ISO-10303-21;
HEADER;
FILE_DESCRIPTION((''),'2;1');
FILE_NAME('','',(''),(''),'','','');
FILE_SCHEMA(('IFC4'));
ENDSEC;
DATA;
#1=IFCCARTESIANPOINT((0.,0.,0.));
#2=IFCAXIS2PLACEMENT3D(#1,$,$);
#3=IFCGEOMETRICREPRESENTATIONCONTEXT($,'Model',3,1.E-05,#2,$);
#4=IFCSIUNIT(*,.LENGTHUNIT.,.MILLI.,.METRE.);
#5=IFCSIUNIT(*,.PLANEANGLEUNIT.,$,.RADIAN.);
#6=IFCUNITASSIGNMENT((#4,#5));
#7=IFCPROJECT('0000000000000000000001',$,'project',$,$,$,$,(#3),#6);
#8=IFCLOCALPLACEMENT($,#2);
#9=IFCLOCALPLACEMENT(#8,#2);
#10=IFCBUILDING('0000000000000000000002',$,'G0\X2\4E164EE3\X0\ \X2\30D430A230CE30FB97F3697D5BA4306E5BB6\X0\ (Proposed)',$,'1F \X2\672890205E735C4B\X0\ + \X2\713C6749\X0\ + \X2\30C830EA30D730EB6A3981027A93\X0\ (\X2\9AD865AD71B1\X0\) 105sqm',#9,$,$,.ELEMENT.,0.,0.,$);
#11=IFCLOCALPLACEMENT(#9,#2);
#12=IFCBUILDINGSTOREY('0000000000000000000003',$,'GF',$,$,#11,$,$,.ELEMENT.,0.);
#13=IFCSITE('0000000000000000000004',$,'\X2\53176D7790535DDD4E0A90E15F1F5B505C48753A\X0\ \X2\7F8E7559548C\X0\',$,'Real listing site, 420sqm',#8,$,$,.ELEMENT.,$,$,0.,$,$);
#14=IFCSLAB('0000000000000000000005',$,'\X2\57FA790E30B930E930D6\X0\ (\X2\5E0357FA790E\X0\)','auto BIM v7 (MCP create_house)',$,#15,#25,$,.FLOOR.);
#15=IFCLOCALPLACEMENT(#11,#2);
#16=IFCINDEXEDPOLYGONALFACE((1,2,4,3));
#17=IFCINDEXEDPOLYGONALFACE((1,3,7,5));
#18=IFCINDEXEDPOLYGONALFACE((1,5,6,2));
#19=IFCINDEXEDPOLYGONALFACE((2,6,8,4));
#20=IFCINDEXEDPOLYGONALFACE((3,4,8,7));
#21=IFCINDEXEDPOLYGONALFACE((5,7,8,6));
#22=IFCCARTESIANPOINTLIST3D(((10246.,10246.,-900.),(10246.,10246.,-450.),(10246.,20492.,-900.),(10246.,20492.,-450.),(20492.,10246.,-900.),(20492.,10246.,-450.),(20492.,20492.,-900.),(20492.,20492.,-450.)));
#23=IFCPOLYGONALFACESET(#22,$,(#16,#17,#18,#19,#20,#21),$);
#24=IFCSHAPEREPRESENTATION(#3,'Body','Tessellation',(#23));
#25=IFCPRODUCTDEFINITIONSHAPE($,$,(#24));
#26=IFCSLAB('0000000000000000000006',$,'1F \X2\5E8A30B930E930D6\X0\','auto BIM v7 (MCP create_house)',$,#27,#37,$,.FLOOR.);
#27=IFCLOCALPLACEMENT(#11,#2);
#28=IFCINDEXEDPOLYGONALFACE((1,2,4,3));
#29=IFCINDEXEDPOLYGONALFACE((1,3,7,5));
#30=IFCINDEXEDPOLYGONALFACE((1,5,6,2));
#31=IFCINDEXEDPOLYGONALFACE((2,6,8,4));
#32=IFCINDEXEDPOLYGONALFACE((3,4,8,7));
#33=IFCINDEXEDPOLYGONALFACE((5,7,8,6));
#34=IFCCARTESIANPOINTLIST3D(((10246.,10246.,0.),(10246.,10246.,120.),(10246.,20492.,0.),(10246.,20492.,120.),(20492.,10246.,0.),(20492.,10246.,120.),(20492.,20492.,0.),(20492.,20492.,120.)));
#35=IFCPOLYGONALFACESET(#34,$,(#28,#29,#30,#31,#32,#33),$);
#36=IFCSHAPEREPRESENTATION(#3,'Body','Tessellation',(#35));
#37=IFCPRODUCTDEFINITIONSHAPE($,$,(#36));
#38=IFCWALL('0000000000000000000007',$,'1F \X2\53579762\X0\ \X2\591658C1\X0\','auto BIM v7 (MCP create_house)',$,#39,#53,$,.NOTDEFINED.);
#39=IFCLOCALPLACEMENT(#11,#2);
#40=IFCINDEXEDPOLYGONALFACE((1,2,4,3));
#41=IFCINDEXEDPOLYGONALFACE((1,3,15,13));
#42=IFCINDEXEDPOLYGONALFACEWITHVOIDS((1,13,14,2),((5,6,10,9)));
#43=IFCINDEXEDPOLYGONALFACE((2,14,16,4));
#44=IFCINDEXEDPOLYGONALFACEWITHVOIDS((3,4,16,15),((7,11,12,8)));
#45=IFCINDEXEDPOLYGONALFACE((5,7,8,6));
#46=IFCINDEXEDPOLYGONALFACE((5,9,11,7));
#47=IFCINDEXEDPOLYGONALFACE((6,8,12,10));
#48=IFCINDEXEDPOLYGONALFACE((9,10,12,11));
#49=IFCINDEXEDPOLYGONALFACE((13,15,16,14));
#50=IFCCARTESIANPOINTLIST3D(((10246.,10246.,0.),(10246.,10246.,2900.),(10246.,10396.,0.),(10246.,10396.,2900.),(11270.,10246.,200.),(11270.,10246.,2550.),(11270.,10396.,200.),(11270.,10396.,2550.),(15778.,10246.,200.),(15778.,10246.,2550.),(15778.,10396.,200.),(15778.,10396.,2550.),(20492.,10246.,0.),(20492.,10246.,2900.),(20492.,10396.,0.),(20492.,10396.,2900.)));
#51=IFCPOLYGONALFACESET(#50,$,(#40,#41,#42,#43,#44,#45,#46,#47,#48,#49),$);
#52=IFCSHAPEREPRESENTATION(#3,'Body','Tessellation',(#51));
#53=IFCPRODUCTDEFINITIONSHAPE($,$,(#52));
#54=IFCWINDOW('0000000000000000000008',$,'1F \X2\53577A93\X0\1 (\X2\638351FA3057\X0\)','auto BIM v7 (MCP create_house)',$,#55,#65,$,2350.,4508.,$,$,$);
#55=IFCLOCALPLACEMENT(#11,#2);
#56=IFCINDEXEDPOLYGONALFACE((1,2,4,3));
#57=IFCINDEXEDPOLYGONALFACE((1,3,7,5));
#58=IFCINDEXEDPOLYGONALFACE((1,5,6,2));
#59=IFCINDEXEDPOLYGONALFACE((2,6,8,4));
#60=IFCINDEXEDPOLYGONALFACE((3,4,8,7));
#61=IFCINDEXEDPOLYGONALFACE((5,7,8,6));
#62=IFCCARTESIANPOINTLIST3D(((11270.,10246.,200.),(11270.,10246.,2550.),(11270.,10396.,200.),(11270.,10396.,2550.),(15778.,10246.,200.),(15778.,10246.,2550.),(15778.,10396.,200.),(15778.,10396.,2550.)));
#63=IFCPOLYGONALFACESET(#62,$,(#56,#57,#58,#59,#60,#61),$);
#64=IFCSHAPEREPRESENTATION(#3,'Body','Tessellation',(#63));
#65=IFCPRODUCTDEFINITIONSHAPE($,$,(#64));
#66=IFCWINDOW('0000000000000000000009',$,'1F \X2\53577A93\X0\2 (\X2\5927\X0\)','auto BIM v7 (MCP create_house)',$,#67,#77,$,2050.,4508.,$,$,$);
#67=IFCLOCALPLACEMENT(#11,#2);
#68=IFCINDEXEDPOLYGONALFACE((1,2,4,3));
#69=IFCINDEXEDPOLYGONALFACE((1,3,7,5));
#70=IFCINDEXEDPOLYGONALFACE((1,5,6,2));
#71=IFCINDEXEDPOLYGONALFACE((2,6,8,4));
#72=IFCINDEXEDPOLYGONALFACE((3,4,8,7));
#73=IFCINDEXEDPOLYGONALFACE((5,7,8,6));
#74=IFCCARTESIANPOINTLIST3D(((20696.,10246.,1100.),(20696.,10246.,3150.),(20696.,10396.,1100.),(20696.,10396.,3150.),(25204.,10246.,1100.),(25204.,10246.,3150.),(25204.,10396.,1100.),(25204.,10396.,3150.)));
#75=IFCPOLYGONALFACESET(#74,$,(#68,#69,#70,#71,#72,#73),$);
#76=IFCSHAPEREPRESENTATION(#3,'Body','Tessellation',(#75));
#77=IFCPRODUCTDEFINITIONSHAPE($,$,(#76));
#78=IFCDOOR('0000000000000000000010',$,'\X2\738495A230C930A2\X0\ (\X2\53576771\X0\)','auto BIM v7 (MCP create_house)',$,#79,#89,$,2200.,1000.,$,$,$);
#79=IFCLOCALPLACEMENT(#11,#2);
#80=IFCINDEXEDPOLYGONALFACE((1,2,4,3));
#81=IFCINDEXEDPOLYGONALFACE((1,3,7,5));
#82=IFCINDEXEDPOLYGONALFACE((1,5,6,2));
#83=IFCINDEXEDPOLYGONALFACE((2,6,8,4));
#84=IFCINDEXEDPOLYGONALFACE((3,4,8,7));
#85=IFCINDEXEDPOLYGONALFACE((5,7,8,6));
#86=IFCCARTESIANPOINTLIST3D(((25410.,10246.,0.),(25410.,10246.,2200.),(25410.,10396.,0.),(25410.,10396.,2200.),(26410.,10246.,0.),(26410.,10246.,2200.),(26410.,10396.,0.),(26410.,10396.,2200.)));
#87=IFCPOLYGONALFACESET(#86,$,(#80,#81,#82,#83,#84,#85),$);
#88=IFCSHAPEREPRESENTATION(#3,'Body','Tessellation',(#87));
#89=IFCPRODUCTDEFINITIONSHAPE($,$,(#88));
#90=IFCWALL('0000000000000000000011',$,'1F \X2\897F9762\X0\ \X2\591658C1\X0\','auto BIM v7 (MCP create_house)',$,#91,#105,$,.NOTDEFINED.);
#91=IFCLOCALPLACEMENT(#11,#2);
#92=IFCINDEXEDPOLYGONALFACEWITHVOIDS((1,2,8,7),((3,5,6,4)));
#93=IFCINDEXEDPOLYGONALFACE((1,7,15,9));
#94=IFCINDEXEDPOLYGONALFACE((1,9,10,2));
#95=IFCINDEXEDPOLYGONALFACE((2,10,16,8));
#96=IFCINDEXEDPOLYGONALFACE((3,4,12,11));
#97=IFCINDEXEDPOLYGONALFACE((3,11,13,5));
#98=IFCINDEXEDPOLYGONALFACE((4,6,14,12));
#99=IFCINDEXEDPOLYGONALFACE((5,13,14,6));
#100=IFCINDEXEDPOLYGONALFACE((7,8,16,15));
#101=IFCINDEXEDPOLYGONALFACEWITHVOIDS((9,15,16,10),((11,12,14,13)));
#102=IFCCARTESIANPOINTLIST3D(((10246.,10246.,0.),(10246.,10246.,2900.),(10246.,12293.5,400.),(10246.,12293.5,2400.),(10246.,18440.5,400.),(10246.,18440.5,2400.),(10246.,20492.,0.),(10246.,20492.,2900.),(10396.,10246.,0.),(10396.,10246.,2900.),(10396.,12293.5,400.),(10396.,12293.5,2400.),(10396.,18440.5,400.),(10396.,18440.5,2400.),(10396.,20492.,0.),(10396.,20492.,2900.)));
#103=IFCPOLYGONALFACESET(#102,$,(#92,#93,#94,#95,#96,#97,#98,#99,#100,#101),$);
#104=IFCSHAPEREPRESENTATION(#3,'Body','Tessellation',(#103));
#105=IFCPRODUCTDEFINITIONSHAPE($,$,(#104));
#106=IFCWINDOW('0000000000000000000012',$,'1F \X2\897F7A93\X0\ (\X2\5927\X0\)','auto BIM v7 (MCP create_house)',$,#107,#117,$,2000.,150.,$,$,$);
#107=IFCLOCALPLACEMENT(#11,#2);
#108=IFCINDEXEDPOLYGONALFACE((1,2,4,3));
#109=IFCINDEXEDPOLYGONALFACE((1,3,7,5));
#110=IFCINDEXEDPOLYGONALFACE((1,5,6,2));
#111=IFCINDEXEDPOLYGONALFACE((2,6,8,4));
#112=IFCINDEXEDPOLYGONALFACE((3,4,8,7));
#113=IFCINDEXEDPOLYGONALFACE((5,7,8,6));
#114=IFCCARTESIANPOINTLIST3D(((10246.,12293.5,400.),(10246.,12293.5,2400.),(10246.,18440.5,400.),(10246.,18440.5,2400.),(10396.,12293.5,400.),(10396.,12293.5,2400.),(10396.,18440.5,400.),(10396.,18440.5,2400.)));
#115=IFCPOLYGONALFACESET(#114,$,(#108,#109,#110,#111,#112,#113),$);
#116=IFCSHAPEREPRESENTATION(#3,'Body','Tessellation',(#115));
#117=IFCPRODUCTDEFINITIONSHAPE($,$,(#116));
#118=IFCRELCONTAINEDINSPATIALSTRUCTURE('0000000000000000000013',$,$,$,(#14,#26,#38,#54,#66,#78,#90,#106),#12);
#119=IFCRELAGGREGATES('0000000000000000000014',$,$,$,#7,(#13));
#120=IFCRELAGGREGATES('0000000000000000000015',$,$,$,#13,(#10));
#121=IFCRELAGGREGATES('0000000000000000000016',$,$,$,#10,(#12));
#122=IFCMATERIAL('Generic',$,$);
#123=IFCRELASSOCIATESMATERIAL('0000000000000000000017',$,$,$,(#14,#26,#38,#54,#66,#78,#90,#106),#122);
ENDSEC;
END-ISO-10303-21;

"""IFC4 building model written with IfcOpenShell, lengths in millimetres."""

from ifc_helpers import new_model, si_unit, frame, frame_2d, origin, place, context, project, spatial, rectangle, extrude, material, element, fill, save


model = new_model("IFC4")

# Units and contexts
model_context = context("Model", 3, precision=1e-05, world=origin())
ifc_project = project(units=[si_unit("LENGTHUNIT", "METRE", prefix="MILLI"), si_unit("PLANEANGLEUNIT", "RADIAN")], contexts=[model_context])

# Site, building, storey
site_placement = place(None, origin())
site = spatial("IfcSite", under=ifc_project, at=site_placement, Name="北海道川上郡弟子屈町 美留和", ObjectType="Real listing site, 420sqm", CompositionType="ELEMENT", RefElevation=0.0)
building_placement = place(site_placement, origin())
building = spatial("IfcBuilding", under=site, at=building_placement, Name="G0世代 ピアノ・音楽室の家 (Proposed)", ObjectType="1F 木造平屋 + 焼杉 + トリプル樹脂窓 (高断熱) 105sqm", CompositionType="ELEMENT", ElevationOfRefHeight=0.0, ElevationOfTerrain=0.0)
storey_placement = place(building_placement, origin())
storey = spatial("IfcBuildingStorey", under=building, at=storey_placement, Name="GF", CompositionType="ELEMENT", Elevation=0.0)

# Slabs
ifc_material = material(Name="Generic")
slab_1_placement = place(storey_placement, frame((5123.0, 5123.0, -450.0)))
element("IfcSlab", 1, at=slab_1_placement, inside=storey, material=ifc_material, Name="基礎スラブ (布基礎)", Description="auto BIM v7 (MCP create_house)", PredefinedType="FLOOR", context=model_context, shape_type="SweptSolid", body=[
    extrude(rectangle(XDim=10246.0, YDim=10246.0, at=frame_2d((5123.0, 5123.0))), frame((5123.0, 5123.0, -450.0)), (0.0, 0.0, 1.0), 450.0),
])
slab_2_placement = place(storey_placement, frame((5123.0, 5123.0, 0.0)))
element("IfcSlab", 2, at=slab_2_placement, inside=storey, material=ifc_material, Name="1F 床スラブ", Description="auto BIM v7 (MCP create_house)", PredefinedType="FLOOR", context=model_context, shape_type="SweptSolid", body=[
    extrude(rectangle(XDim=10246.0, YDim=10246.0, at=frame_2d((5123.0, 5123.0))), frame((5123.0, 5123.0, 0.0)), (0.0, 0.0, 1.0), 120.0),
])

# Wall, openings, windows, door
wall_1_placement = place(storey_placement, frame((5123.0, 5123.0, 0.0)))
wall_1 = element("IfcWall", 3, at=wall_1_placement, inside=storey, material=ifc_material, Name="1F 南面 外壁", Description="auto BIM v7 (MCP create_house)", PredefinedType="NOTDEFINED", context=model_context, shape_type="SweptSolid", body=[
    extrude(rectangle(XDim=10246.0, YDim=150.0, at=frame_2d((5123.0, 75.0))), frame((5123.0, 5123.0, 0.0)), (0.0, 0.0, 1.0), 2900.0),
])
opening_1_placement = place(storey_placement, frame((5635.0, 5123.0, 100.0)))
opening_1 = element("IfcOpeningElement", 4, at=opening_1_placement, cuts=wall_1, PredefinedType="NOTDEFINED", context=model_context, shape_type="SweptSolid", body=[
    extrude(rectangle(XDim=4508.0, YDim=150.0, at=frame_2d((2254.0, 75.0))), frame((5635.0, 5123.0, 100.0)), (0.0, 0.0, 1.0), 2350.0),
])
opening_2_placement = place(storey_placement, frame((10348.0, 5123.0, 550.0)))
opening_2 = element("IfcOpeningElement", 5, at=opening_2_placement, cuts=wall_1, PredefinedType="NOTDEFINED", context=model_context, shape_type="SweptSolid", body=[
    extrude(rectangle(XDim=4508.0, YDim=150.0, at=frame_2d((2254.0, 75.0))), frame((10348.0, 5123.0, 550.0)), (0.0, 0.0, 1.0), 2050.0),
])
opening_3_placement = place(storey_placement, frame((12705.0, 5123.0, 0.0)))
opening_3 = element("IfcOpeningElement", 6, at=opening_3_placement, cuts=wall_1, PredefinedType="NOTDEFINED", context=model_context, shape_type="SweptSolid", body=[
    extrude(rectangle(XDim=1000.0, YDim=150.0, at=frame_2d((500.0, 75.0))), frame((12705.0, 5123.0, 0.0)), (0.0, 0.0, 1.0), 2200.0),
])
window_1_placement = place(storey_placement, frame((5635.0, 5123.0, 100.0)))
window_1 = element("IfcWindow", 7, at=window_1_placement, inside=storey, material=ifc_material, Name="1F 南窓1 (掃出し)", Description="auto BIM v7 (MCP create_house)", OverallHeight=2350.0, OverallWidth=4508.0, context=model_context, shape_type="SweptSolid", body=[
    extrude(rectangle(XDim=4508.0, YDim=150.0, at=frame_2d((2254.0, 75.0))), frame((5635.0, 5123.0, 100.0)), (0.0, 0.0, 1.0), 2350.0),
])
fill(opening_1, window_1)
window_2_placement = place(storey_placement, frame((10348.0, 5123.0, 550.0)))
window_2 = element("IfcWindow", 8, at=window_2_placement, inside=storey, material=ifc_material, Name="1F 南窓2 (大)", Description="auto BIM v7 (MCP create_house)", OverallHeight=2050.0, OverallWidth=4508.0, context=model_context, shape_type="SweptSolid", body=[
    extrude(rectangle(XDim=4508.0, YDim=150.0, at=frame_2d((2254.0, 75.0))), frame((10348.0, 5123.0, 550.0)), (0.0, 0.0, 1.0), 2050.0),
])
fill(opening_2, window_2)
door_placement = place(storey_placement, frame((12705.0, 5123.0, 0.0)))
door = element("IfcDoor", 9, at=door_placement, inside=storey, material=ifc_material, Name="玄関ドア (南東)", Description="auto BIM v7 (MCP create_house)", OverallHeight=2200.0, OverallWidth=1000.0, context=model_context, shape_type="SweptSolid", body=[
    extrude(rectangle(XDim=1000.0, YDim=150.0, at=frame_2d((500.0, 75.0))), frame((12705.0, 5123.0, 0.0)), (0.0, 0.0, 1.0), 2200.0),
])
fill(opening_3, door)

# Wall, opening, window
wall_2_placement = place(storey_placement, frame((5123.0, 5123.0, 0.0)))
wall_2 = element("IfcWall", 10, at=wall_2_placement, inside=storey, material=ifc_material, Name="1F 西面 外壁", Description="auto BIM v7 (MCP create_house)", PredefinedType="NOTDEFINED", context=model_context, shape_type="SweptSolid", body=[
    extrude(rectangle(XDim=150.0, YDim=10246.0, at=frame_2d((75.0, 5123.0))), frame((5123.0, 5123.0, 0.0)), (0.0, 0.0, 1.0), 2900.0),
])
opening_4_placement = place(storey_placement, frame((5123.0, 6147.0, 200.0)))
opening_4 = element("IfcOpeningElement", 11, at=opening_4_placement, cuts=wall_2, PredefinedType="NOTDEFINED", context=model_context, shape_type="SweptSolid", body=[
    extrude(rectangle(XDim=150.0, YDim=6147.0, at=frame_2d((75.0, 3073.0))), frame((5123.0, 6147.0, 200.0)), (0.0, 0.0, 1.0), 2000.0),
])
window_3_placement = place(storey_placement, frame((5123.0, 6147.0, 200.0)))
window_3 = element("IfcWindow", 12, at=window_3_placement, inside=storey, material=ifc_material, Name="1F 西窓 (大)", Description="auto BIM v7 (MCP create_house)", OverallHeight=2000.0, OverallWidth=150.0, context=model_context, shape_type="SweptSolid", body=[
    extrude(rectangle(XDim=150.0, YDim=6147.0, at=frame_2d((75.0, 3073.0))), frame((5123.0, 6147.0, 200.0)), (0.0, 0.0, 1.0), 2000.0),
])
fill(opening_4, window_3)

save(model, "model.ifc")
